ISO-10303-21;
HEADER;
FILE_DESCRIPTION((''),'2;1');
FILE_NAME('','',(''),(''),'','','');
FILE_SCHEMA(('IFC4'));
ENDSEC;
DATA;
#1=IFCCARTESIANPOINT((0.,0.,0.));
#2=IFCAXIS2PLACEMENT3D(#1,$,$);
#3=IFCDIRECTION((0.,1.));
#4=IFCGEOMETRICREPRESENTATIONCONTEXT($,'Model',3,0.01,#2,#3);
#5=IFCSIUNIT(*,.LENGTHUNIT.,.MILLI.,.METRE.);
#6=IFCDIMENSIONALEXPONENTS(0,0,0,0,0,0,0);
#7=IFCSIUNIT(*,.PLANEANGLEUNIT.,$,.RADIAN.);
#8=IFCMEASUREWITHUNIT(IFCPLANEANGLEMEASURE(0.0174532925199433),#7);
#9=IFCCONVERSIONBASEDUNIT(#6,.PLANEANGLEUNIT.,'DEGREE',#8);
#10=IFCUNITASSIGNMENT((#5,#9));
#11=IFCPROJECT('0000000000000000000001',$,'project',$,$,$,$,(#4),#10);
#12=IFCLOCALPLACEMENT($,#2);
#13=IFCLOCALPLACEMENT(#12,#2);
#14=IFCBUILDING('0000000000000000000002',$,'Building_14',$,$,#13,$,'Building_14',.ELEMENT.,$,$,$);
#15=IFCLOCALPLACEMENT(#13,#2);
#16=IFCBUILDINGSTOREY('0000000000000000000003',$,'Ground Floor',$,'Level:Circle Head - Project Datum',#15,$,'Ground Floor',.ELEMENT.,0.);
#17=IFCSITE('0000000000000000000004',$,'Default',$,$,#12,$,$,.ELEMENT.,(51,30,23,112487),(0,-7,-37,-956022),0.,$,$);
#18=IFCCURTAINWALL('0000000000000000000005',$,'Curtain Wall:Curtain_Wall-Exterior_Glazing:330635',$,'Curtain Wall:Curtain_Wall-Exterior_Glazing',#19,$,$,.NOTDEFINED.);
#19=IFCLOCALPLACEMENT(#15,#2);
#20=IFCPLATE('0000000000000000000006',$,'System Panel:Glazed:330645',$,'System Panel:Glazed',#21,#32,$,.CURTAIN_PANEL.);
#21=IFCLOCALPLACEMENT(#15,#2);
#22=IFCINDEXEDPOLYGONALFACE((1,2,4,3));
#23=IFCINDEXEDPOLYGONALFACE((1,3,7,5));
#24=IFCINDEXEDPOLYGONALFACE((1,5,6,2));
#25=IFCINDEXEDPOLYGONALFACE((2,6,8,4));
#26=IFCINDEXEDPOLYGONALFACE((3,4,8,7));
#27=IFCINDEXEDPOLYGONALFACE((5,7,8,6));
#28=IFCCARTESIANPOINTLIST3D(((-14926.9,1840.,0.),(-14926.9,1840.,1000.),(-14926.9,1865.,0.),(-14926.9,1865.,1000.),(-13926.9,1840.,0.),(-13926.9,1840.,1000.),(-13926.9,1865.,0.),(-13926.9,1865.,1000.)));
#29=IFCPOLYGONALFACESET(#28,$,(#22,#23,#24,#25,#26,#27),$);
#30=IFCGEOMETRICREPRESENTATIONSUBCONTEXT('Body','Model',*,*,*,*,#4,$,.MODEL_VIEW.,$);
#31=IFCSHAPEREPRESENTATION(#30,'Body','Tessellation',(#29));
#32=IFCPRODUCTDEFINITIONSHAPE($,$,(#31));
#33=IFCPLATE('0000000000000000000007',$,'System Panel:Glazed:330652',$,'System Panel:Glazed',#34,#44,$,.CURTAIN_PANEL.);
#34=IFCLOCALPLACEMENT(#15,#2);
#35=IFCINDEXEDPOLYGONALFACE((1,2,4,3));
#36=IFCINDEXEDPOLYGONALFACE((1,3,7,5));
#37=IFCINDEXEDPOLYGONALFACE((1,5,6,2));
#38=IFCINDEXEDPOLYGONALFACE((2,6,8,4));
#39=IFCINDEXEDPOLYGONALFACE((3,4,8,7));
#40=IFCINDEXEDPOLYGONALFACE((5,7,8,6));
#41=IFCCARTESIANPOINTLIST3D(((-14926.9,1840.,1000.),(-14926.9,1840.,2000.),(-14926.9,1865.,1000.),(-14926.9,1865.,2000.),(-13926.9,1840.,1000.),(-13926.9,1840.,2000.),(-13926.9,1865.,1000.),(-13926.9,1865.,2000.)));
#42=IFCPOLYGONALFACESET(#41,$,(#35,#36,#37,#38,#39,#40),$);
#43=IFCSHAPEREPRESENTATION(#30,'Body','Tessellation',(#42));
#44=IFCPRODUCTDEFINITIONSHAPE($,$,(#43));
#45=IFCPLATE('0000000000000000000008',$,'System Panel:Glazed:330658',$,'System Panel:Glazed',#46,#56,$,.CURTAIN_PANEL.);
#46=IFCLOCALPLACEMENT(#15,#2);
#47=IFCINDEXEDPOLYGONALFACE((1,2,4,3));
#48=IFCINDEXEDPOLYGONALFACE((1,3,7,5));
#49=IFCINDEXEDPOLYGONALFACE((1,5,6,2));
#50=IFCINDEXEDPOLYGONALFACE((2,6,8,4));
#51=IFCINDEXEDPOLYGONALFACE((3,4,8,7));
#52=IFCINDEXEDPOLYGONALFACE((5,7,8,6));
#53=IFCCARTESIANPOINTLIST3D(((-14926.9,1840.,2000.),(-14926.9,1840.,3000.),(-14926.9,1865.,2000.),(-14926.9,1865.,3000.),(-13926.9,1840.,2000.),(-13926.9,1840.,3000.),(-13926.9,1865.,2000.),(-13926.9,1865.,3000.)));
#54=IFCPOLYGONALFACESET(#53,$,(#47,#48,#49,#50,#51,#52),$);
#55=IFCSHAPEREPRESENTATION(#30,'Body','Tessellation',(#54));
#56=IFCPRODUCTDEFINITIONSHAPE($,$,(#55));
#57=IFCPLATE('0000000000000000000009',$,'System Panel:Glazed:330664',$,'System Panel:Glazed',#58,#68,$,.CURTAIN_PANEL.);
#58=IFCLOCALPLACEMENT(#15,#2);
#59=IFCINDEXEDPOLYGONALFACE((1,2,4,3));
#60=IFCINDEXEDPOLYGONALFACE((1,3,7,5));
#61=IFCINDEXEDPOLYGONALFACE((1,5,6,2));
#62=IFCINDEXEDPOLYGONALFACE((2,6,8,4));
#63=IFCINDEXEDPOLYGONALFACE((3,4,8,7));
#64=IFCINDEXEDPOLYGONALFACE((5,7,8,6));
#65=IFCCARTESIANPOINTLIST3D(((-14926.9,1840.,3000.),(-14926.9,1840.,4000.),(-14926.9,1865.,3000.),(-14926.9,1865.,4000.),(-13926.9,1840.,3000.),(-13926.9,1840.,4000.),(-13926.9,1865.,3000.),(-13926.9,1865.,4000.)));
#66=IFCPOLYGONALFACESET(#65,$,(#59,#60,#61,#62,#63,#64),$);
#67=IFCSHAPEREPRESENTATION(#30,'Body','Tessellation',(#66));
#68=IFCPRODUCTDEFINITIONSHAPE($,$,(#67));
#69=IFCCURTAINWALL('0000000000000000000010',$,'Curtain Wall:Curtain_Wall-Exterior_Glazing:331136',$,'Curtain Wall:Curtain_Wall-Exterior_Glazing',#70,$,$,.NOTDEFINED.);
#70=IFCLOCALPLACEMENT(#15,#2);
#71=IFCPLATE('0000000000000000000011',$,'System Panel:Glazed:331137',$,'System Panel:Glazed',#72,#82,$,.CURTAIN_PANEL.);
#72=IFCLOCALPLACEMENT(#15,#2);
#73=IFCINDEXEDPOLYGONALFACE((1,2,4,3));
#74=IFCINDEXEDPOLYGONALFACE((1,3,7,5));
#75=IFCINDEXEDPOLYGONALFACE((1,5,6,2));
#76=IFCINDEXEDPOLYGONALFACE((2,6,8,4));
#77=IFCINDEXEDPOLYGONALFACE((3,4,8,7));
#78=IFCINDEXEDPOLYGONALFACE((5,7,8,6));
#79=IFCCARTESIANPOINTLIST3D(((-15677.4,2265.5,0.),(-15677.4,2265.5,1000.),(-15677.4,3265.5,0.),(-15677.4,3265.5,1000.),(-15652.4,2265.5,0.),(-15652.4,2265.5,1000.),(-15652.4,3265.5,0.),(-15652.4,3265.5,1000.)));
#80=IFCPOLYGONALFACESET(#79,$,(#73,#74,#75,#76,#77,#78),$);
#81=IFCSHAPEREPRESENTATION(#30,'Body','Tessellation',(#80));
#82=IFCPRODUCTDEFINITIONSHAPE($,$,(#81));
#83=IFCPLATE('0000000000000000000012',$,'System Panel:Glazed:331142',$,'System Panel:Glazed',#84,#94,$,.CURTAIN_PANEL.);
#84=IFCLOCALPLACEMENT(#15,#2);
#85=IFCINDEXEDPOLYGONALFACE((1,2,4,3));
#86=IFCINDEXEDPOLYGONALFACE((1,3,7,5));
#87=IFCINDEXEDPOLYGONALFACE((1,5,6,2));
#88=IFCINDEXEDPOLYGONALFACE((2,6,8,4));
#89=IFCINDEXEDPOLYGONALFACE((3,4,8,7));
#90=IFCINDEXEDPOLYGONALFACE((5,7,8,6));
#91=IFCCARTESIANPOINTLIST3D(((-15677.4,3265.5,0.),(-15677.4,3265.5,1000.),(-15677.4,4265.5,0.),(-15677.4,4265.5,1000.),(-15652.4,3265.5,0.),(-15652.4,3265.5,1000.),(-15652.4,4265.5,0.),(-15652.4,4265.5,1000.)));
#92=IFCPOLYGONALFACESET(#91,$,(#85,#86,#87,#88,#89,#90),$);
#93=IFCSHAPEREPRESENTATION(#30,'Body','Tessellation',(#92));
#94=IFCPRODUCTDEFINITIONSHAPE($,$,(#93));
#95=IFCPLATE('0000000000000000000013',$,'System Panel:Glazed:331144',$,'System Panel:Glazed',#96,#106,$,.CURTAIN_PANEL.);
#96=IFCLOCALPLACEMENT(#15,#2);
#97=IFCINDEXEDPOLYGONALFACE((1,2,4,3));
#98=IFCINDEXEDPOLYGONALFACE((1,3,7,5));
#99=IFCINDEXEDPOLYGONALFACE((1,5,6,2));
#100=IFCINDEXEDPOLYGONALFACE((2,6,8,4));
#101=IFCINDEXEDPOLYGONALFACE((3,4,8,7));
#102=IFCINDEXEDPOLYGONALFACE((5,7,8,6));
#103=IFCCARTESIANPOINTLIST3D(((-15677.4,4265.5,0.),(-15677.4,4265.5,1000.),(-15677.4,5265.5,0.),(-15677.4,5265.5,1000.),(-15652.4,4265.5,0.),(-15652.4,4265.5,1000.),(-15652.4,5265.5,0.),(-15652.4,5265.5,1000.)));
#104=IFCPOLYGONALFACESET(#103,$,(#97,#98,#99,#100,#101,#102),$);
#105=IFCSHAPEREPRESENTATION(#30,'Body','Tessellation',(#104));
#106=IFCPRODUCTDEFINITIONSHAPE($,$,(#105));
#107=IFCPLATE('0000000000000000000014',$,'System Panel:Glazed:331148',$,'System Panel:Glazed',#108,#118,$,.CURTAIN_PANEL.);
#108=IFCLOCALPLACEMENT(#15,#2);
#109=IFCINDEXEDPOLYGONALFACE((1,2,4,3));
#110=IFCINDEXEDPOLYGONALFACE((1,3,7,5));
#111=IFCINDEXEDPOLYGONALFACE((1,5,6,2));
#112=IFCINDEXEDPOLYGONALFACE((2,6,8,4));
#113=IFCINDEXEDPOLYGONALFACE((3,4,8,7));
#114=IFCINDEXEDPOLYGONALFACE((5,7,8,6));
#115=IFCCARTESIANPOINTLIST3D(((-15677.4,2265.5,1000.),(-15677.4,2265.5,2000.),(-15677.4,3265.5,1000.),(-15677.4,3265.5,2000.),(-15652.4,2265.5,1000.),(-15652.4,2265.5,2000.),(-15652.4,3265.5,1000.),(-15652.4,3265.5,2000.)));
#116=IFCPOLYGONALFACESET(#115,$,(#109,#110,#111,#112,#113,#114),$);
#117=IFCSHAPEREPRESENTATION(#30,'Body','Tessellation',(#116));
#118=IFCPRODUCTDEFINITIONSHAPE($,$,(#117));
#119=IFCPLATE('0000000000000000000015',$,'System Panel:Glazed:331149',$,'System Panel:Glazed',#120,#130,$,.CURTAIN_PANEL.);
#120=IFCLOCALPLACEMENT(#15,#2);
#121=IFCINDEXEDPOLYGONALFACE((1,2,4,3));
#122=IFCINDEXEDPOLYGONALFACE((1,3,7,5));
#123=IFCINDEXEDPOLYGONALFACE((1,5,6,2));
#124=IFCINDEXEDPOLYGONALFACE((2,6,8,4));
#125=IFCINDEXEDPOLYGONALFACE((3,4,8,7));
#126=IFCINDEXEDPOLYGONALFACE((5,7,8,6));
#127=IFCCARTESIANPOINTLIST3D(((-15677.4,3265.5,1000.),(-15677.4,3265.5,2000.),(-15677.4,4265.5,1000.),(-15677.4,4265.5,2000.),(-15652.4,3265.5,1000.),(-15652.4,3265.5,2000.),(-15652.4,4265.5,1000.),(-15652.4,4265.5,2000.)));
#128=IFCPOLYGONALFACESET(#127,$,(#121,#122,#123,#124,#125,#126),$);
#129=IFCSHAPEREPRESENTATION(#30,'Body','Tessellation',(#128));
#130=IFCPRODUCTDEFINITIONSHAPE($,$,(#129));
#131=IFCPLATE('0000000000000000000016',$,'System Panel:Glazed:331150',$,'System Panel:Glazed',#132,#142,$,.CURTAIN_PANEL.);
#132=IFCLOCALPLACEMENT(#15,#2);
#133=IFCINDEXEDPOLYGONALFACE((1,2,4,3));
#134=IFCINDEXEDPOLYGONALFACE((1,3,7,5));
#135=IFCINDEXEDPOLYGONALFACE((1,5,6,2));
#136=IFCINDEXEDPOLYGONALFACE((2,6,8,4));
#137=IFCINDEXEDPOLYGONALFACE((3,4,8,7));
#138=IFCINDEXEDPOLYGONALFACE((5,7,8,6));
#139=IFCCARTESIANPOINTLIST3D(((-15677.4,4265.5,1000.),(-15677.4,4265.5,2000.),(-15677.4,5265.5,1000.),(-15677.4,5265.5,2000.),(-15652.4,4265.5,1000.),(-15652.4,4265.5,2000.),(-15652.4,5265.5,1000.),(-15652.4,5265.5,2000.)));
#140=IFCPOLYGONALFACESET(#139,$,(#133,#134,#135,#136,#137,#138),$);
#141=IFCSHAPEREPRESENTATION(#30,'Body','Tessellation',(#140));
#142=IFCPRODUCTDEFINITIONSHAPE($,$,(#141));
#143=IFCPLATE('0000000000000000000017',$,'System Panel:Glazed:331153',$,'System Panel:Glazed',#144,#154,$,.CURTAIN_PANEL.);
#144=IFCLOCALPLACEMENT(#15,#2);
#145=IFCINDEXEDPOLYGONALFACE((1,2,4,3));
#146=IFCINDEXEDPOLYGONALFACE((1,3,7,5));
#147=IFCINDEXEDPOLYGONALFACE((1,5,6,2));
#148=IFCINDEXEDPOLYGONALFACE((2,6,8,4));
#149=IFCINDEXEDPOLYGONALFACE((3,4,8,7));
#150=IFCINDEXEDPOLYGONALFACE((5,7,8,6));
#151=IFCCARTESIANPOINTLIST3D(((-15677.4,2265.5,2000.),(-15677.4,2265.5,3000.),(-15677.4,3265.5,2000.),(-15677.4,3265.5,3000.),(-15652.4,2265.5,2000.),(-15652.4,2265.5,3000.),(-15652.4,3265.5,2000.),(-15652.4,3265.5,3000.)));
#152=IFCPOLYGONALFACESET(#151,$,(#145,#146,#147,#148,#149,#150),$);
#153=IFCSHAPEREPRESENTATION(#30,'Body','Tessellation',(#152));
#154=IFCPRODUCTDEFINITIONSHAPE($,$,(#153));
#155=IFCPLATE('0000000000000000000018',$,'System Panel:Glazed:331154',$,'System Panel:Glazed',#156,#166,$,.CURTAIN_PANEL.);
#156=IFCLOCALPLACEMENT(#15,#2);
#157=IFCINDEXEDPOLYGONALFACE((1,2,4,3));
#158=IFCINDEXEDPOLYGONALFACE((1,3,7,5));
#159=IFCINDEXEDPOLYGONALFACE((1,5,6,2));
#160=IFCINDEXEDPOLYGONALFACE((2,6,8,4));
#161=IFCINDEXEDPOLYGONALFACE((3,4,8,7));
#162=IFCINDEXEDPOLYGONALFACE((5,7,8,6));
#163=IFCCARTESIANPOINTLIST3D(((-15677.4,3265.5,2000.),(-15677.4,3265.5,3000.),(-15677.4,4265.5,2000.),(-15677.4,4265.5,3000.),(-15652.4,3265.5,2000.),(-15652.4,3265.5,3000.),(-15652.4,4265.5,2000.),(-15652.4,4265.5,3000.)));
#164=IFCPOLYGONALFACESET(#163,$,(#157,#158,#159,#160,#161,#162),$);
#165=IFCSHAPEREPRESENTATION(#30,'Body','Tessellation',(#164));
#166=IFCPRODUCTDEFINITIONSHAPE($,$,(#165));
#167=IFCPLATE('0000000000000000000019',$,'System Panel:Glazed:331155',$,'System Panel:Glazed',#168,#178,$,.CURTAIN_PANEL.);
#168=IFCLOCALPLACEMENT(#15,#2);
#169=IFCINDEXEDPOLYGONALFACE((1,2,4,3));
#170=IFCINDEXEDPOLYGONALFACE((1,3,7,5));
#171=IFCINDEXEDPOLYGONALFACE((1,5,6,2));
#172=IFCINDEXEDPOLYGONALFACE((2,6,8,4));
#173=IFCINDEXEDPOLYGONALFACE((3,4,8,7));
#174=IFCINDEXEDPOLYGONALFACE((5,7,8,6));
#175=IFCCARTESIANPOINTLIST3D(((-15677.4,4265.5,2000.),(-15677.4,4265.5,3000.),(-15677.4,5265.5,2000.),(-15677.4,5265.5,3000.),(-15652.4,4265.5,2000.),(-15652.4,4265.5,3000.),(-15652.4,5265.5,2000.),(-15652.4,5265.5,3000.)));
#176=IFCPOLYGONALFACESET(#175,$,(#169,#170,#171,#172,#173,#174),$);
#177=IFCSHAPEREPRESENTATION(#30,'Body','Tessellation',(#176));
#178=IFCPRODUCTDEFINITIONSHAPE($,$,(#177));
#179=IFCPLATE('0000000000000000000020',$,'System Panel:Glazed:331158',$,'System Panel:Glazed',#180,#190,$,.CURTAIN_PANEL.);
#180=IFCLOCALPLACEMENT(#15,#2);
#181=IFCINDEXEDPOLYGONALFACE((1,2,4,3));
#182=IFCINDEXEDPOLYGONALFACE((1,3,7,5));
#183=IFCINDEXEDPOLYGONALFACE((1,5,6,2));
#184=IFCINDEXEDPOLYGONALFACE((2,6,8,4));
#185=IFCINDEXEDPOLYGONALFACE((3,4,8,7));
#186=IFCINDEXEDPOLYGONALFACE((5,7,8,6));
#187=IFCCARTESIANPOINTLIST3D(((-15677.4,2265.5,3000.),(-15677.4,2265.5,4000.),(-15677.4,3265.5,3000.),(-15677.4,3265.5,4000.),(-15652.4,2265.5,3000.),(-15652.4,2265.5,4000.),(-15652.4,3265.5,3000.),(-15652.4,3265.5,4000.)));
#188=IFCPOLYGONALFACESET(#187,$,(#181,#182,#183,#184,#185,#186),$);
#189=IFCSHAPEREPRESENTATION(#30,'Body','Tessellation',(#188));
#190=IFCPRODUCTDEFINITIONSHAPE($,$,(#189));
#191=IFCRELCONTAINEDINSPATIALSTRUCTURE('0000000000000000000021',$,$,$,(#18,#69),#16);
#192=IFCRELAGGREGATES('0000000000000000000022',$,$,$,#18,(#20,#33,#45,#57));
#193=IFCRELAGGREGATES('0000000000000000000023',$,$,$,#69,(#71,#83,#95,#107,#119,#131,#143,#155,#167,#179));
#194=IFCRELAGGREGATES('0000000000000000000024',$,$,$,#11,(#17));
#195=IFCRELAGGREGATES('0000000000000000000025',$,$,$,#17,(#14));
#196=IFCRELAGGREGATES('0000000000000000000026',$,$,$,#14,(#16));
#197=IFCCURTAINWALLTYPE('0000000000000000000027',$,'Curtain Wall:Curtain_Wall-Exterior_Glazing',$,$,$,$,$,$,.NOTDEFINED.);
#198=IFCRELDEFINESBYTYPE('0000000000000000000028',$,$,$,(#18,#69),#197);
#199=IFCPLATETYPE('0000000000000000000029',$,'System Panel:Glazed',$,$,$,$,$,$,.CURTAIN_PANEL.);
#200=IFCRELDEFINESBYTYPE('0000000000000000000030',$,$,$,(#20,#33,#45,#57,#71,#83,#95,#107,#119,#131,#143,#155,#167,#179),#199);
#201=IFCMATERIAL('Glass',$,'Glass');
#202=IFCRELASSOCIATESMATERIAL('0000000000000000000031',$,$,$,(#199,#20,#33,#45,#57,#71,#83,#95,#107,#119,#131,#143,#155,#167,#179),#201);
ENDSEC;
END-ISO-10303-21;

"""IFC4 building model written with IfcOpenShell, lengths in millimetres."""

from ifc_helpers import new_model, entity, si_unit, converted_unit, direction, frame, origin, place, context, subcontext, project, spatial, indexed_curve, outline, extrude, source, transform, mapped, material, type_object, type_shapes, element, aggregate, save


model = new_model("IFC4")

# Units and contexts
model_context = context("Model", 3, precision=0.01, world=origin(), true_north=direction((0.0, 1.0)))
body_context = subcontext(model_context, "Body", "Model", "MODEL_VIEW")
ifc_project = project(units=[si_unit("LENGTHUNIT", "METRE", prefix="MILLI"), converted_unit("PLANEANGLEUNIT", "DEGREE", entity("IfcPlaneAngleMeasure", 0.0174532925199433), si_unit("PLANEANGLEUNIT", "RADIAN"), dimensions=[0, 0, 0, 0, 0, 0, 0])], contexts=[model_context])

# Site, building, storey
site_placement = place(None, origin())
site = spatial("IfcSite", under=ifc_project, at=site_placement, Name="Default", CompositionType="ELEMENT", RefLatitude=(51, 30, 23, 112487), RefLongitude=(0, -7, -37, -956022), RefElevation=0.0)
building_placement = place(site_placement, origin())
building = spatial("IfcBuilding", under=site, at=building_placement, Name="Building_14", LongName="Building_14", CompositionType="ELEMENT")
storey_placement = place(building_placement, origin())
storey = spatial("IfcBuildingStorey", under=building, at=storey_placement, Name="Ground Floor", ObjectType="Level:Circle Head - Project Datum", LongName="Ground Floor", CompositionType="ELEMENT", Elevation=0.0)

# Curtain walls, plates
curtain_wall_type = type_object("IfcCurtainWallType", Name="Curtain Wall:Curtain_Wall-Exterior_Glazing", PredefinedType="NOTDEFINED")
curtain_wall_1_placement = place(storey_placement, origin())
curtain_wall_1 = element("IfcCurtainWall", 1, at=curtain_wall_1_placement, inside=storey, type_object=curtain_wall_type, Name="Curtain Wall:Curtain_Wall-Exterior_Glazing:330635", ObjectType="Curtain Wall:Curtain_Wall-Exterior_Glazing", PredefinedType="NOTDEFINED")
ifc_material = material(Name="Glass", Category="Glass")
plate_type_1 = type_object("IfcPlateType", Name="System Panel:Glazed", PredefinedType="CURTAIN_PANEL", material=ifc_material)
shared_shape_1 = source(origin(), body_context, "Body", "SweptSolid", [
    extrude(outline(indexed_curve([(-12.5, -500.0), (12.5, -500.0), (12.5, 500.0), (-12.5, 500.0), (-12.5, -500.0)], self_intersect=False)), frame((0.0, -37.0, 0.0), z_axis=(0.0, 0.0, 1.0), x_axis=(0.0, 1.0, 0.0)), (0.0, 0.0, 1.0), 1000.0),
])
type_shapes(plate_type_1, [shared_shape_1])
plate_1_placement = place(curtain_wall_1_placement, frame((-14426.9, 1815.5, 0.0), z_axis=(0.0, 0.0, 1.0), x_axis=(-1.0, 0.0, 0.0)))
plate_1 = element("IfcPlate", 2, at=plate_1_placement, type_object=plate_type_1, material=ifc_material, Name="System Panel:Glazed:330645", ObjectType="System Panel:Glazed", PredefinedType="CURTAIN_PANEL", context=body_context, shape_type="MappedRepresentation", body=[
    mapped(shared_shape_1, transform((0.0, 0.0, 0.0), scale=1.0)),
])
plate_2_placement = place(curtain_wall_1_placement, frame((-14426.9, 1815.5, 1000.0), z_axis=(0.0, 0.0, 1.0), x_axis=(-1.0, 0.0, 0.0)))
plate_2 = element("IfcPlate", 3, at=plate_2_placement, type_object=plate_type_1, material=ifc_material, Name="System Panel:Glazed:330652", ObjectType="System Panel:Glazed", PredefinedType="CURTAIN_PANEL", context=body_context, shape_type="MappedRepresentation", body=[
    mapped(shared_shape_1, transform((0.0, 0.0, 0.0), scale=1.0)),
])
plate_3_placement = place(curtain_wall_1_placement, frame((-14426.9, 1815.5, 2000.0), z_axis=(0.0, 0.0, 1.0), x_axis=(-1.0, 0.0, 0.0)))
plate_3 = element("IfcPlate", 4, at=plate_3_placement, type_object=plate_type_1, material=ifc_material, Name="System Panel:Glazed:330658", ObjectType="System Panel:Glazed", PredefinedType="CURTAIN_PANEL", context=body_context, shape_type="MappedRepresentation", body=[
    mapped(shared_shape_1, transform((0.0, 0.0, 0.0), scale=1.0)),
])
plate_4_placement = place(curtain_wall_1_placement, frame((-14426.9, 1815.5, 3000.0), z_axis=(0.0, 0.0, 1.0), x_axis=(-1.0, 0.0, 0.0)))
plate_4 = element("IfcPlate", 5, at=plate_4_placement, type_object=plate_type_1, material=ifc_material, Name="System Panel:Glazed:330664", ObjectType="System Panel:Glazed", PredefinedType="CURTAIN_PANEL", context=body_context, shape_type="MappedRepresentation", body=[
    mapped(shared_shape_1, transform((0.0, 0.0, 0.0), scale=1.0)),
])
curtain_wall_2_placement = place(storey_placement, origin())
curtain_wall_2 = element("IfcCurtainWall", 6, at=curtain_wall_2_placement, inside=storey, type_object=curtain_wall_type, Name="Curtain Wall:Curtain_Wall-Exterior_Glazing:331136", ObjectType="Curtain Wall:Curtain_Wall-Exterior_Glazing", PredefinedType="NOTDEFINED")
plate_5_placement = place(curtain_wall_2_placement, frame((-15701.9, 2765.5, 0.0), z_axis=(0.0, 0.0, 1.0), x_axis=(0.0, 1.0, 0.0)))
plate_5 = element("IfcPlate", 7, at=plate_5_placement, type_object=plate_type_1, material=ifc_material, Name="System Panel:Glazed:331137", ObjectType="System Panel:Glazed", PredefinedType="CURTAIN_PANEL", context=body_context, shape_type="MappedRepresentation", body=[
    mapped(shared_shape_1, transform((0.0, 0.0, 0.0), scale=1.0)),
])
plate_6_placement = place(curtain_wall_2_placement, frame((-15701.9, 3765.5, 0.0), z_axis=(0.0, 0.0, 1.0), x_axis=(0.0, 1.0, 0.0)))
plate_6 = element("IfcPlate", 8, at=plate_6_placement, type_object=plate_type_1, material=ifc_material, Name="System Panel:Glazed:331142", ObjectType="System Panel:Glazed", PredefinedType="CURTAIN_PANEL", context=body_context, shape_type="MappedRepresentation", body=[
    mapped(shared_shape_1, transform((0.0, 0.0, 0.0), scale=1.0)),
])
plate_7_placement = place(curtain_wall_2_placement, frame((-15701.9, 4765.5, 0.0), z_axis=(0.0, 0.0, 1.0), x_axis=(0.0, 1.0, 0.0)))
plate_7 = element("IfcPlate", 9, at=plate_7_placement, type_object=plate_type_1, material=ifc_material, Name="System Panel:Glazed:331144", ObjectType="System Panel:Glazed", PredefinedType="CURTAIN_PANEL", context=body_context, shape_type="MappedRepresentation", body=[
    mapped(shared_shape_1, transform((0.0, 0.0, 0.0), scale=1.0)),
])
plate_8_placement = place(curtain_wall_2_placement, frame((-15701.9, 2765.5, 1000.0), z_axis=(0.0, 0.0, 1.0), x_axis=(0.0, 1.0, 0.0)))
plate_8 = element("IfcPlate", 10, at=plate_8_placement, type_object=plate_type_1, material=ifc_material, Name="System Panel:Glazed:331148", ObjectType="System Panel:Glazed", PredefinedType="CURTAIN_PANEL", context=body_context, shape_type="MappedRepresentation", body=[
    mapped(shared_shape_1, transform((0.0, 0.0, 0.0), scale=1.0)),
])
plate_9_placement = place(curtain_wall_2_placement, frame((-15701.9, 3765.5, 1000.0), z_axis=(0.0, 0.0, 1.0), x_axis=(0.0, 1.0, 0.0)))
plate_9 = element("IfcPlate", 11, at=plate_9_placement, type_object=plate_type_1, material=ifc_material, Name="System Panel:Glazed:331149", ObjectType="System Panel:Glazed", PredefinedType="CURTAIN_PANEL", context=body_context, shape_type="MappedRepresentation", body=[
    mapped(shared_shape_1, transform((0.0, 0.0, 0.0), scale=1.0)),
])
plate_10_placement = place(curtain_wall_2_placement, frame((-15701.9, 4765.5, 1000.0), z_axis=(0.0, 0.0, 1.0), x_axis=(0.0, 1.0, 0.0)))
plate_10 = element("IfcPlate", 12, at=plate_10_placement, type_object=plate_type_1, material=ifc_material, Name="System Panel:Glazed:331150", ObjectType="System Panel:Glazed", PredefinedType="CURTAIN_PANEL", context=body_context, shape_type="MappedRepresentation", body=[
    mapped(shared_shape_1, transform((0.0, 0.0, 0.0), scale=1.0)),
])
plate_11_placement = place(curtain_wall_2_placement, frame((-15701.9, 2765.5, 2000.0), z_axis=(0.0, 0.0, 1.0), x_axis=(0.0, 1.0, 0.0)))
plate_11 = element("IfcPlate", 13, at=plate_11_placement, type_object=plate_type_1, material=ifc_material, Name="System Panel:Glazed:331153", ObjectType="System Panel:Glazed", PredefinedType="CURTAIN_PANEL", context=body_context, shape_type="MappedRepresentation", body=[
    mapped(shared_shape_1, transform((0.0, 0.0, 0.0), scale=1.0)),
])
plate_12_placement = place(curtain_wall_2_placement, frame((-15701.9, 3765.5, 2000.0), z_axis=(0.0, 0.0, 1.0), x_axis=(0.0, 1.0, 0.0)))
plate_12 = element("IfcPlate", 14, at=plate_12_placement, type_object=plate_type_1, material=ifc_material, Name="System Panel:Glazed:331154", ObjectType="System Panel:Glazed", PredefinedType="CURTAIN_PANEL", context=body_context, shape_type="MappedRepresentation", body=[
    mapped(shared_shape_1, transform((0.0, 0.0, 0.0), scale=1.0)),
])
plate_13_placement = place(curtain_wall_2_placement, frame((-15701.9, 4765.5, 2000.0), z_axis=(0.0, 0.0, 1.0), x_axis=(0.0, 1.0, 0.0)))
plate_13 = element("IfcPlate", 15, at=plate_13_placement, type_object=plate_type_1, material=ifc_material, Name="System Panel:Glazed:331155", ObjectType="System Panel:Glazed", PredefinedType="CURTAIN_PANEL", context=body_context, shape_type="MappedRepresentation", body=[
    mapped(shared_shape_1, transform((0.0, 0.0, 0.0), scale=1.0)),
])
plate_14_placement = place(curtain_wall_2_placement, frame((-15701.9, 2765.5, 3000.0), z_axis=(0.0, 0.0, 1.0), x_axis=(0.0, 1.0, 0.0)))
plate_14 = element("IfcPlate", 16, at=plate_14_placement, type_object=plate_type_1, material=ifc_material, Name="System Panel:Glazed:331158", ObjectType="System Panel:Glazed", PredefinedType="CURTAIN_PANEL", context=body_context, shape_type="MappedRepresentation", body=[
    mapped(shared_shape_1, transform((0.0, 0.0, 0.0), scale=1.0)),
])

aggregate(curtain_wall_1, [plate_1, plate_2, plate_3, plate_4])
aggregate(curtain_wall_2, [plate_5, plate_6, plate_7, plate_8, plate_9, plate_10, plate_11, plate_12, plate_13, plate_14])

save(model, "model.ifc")
